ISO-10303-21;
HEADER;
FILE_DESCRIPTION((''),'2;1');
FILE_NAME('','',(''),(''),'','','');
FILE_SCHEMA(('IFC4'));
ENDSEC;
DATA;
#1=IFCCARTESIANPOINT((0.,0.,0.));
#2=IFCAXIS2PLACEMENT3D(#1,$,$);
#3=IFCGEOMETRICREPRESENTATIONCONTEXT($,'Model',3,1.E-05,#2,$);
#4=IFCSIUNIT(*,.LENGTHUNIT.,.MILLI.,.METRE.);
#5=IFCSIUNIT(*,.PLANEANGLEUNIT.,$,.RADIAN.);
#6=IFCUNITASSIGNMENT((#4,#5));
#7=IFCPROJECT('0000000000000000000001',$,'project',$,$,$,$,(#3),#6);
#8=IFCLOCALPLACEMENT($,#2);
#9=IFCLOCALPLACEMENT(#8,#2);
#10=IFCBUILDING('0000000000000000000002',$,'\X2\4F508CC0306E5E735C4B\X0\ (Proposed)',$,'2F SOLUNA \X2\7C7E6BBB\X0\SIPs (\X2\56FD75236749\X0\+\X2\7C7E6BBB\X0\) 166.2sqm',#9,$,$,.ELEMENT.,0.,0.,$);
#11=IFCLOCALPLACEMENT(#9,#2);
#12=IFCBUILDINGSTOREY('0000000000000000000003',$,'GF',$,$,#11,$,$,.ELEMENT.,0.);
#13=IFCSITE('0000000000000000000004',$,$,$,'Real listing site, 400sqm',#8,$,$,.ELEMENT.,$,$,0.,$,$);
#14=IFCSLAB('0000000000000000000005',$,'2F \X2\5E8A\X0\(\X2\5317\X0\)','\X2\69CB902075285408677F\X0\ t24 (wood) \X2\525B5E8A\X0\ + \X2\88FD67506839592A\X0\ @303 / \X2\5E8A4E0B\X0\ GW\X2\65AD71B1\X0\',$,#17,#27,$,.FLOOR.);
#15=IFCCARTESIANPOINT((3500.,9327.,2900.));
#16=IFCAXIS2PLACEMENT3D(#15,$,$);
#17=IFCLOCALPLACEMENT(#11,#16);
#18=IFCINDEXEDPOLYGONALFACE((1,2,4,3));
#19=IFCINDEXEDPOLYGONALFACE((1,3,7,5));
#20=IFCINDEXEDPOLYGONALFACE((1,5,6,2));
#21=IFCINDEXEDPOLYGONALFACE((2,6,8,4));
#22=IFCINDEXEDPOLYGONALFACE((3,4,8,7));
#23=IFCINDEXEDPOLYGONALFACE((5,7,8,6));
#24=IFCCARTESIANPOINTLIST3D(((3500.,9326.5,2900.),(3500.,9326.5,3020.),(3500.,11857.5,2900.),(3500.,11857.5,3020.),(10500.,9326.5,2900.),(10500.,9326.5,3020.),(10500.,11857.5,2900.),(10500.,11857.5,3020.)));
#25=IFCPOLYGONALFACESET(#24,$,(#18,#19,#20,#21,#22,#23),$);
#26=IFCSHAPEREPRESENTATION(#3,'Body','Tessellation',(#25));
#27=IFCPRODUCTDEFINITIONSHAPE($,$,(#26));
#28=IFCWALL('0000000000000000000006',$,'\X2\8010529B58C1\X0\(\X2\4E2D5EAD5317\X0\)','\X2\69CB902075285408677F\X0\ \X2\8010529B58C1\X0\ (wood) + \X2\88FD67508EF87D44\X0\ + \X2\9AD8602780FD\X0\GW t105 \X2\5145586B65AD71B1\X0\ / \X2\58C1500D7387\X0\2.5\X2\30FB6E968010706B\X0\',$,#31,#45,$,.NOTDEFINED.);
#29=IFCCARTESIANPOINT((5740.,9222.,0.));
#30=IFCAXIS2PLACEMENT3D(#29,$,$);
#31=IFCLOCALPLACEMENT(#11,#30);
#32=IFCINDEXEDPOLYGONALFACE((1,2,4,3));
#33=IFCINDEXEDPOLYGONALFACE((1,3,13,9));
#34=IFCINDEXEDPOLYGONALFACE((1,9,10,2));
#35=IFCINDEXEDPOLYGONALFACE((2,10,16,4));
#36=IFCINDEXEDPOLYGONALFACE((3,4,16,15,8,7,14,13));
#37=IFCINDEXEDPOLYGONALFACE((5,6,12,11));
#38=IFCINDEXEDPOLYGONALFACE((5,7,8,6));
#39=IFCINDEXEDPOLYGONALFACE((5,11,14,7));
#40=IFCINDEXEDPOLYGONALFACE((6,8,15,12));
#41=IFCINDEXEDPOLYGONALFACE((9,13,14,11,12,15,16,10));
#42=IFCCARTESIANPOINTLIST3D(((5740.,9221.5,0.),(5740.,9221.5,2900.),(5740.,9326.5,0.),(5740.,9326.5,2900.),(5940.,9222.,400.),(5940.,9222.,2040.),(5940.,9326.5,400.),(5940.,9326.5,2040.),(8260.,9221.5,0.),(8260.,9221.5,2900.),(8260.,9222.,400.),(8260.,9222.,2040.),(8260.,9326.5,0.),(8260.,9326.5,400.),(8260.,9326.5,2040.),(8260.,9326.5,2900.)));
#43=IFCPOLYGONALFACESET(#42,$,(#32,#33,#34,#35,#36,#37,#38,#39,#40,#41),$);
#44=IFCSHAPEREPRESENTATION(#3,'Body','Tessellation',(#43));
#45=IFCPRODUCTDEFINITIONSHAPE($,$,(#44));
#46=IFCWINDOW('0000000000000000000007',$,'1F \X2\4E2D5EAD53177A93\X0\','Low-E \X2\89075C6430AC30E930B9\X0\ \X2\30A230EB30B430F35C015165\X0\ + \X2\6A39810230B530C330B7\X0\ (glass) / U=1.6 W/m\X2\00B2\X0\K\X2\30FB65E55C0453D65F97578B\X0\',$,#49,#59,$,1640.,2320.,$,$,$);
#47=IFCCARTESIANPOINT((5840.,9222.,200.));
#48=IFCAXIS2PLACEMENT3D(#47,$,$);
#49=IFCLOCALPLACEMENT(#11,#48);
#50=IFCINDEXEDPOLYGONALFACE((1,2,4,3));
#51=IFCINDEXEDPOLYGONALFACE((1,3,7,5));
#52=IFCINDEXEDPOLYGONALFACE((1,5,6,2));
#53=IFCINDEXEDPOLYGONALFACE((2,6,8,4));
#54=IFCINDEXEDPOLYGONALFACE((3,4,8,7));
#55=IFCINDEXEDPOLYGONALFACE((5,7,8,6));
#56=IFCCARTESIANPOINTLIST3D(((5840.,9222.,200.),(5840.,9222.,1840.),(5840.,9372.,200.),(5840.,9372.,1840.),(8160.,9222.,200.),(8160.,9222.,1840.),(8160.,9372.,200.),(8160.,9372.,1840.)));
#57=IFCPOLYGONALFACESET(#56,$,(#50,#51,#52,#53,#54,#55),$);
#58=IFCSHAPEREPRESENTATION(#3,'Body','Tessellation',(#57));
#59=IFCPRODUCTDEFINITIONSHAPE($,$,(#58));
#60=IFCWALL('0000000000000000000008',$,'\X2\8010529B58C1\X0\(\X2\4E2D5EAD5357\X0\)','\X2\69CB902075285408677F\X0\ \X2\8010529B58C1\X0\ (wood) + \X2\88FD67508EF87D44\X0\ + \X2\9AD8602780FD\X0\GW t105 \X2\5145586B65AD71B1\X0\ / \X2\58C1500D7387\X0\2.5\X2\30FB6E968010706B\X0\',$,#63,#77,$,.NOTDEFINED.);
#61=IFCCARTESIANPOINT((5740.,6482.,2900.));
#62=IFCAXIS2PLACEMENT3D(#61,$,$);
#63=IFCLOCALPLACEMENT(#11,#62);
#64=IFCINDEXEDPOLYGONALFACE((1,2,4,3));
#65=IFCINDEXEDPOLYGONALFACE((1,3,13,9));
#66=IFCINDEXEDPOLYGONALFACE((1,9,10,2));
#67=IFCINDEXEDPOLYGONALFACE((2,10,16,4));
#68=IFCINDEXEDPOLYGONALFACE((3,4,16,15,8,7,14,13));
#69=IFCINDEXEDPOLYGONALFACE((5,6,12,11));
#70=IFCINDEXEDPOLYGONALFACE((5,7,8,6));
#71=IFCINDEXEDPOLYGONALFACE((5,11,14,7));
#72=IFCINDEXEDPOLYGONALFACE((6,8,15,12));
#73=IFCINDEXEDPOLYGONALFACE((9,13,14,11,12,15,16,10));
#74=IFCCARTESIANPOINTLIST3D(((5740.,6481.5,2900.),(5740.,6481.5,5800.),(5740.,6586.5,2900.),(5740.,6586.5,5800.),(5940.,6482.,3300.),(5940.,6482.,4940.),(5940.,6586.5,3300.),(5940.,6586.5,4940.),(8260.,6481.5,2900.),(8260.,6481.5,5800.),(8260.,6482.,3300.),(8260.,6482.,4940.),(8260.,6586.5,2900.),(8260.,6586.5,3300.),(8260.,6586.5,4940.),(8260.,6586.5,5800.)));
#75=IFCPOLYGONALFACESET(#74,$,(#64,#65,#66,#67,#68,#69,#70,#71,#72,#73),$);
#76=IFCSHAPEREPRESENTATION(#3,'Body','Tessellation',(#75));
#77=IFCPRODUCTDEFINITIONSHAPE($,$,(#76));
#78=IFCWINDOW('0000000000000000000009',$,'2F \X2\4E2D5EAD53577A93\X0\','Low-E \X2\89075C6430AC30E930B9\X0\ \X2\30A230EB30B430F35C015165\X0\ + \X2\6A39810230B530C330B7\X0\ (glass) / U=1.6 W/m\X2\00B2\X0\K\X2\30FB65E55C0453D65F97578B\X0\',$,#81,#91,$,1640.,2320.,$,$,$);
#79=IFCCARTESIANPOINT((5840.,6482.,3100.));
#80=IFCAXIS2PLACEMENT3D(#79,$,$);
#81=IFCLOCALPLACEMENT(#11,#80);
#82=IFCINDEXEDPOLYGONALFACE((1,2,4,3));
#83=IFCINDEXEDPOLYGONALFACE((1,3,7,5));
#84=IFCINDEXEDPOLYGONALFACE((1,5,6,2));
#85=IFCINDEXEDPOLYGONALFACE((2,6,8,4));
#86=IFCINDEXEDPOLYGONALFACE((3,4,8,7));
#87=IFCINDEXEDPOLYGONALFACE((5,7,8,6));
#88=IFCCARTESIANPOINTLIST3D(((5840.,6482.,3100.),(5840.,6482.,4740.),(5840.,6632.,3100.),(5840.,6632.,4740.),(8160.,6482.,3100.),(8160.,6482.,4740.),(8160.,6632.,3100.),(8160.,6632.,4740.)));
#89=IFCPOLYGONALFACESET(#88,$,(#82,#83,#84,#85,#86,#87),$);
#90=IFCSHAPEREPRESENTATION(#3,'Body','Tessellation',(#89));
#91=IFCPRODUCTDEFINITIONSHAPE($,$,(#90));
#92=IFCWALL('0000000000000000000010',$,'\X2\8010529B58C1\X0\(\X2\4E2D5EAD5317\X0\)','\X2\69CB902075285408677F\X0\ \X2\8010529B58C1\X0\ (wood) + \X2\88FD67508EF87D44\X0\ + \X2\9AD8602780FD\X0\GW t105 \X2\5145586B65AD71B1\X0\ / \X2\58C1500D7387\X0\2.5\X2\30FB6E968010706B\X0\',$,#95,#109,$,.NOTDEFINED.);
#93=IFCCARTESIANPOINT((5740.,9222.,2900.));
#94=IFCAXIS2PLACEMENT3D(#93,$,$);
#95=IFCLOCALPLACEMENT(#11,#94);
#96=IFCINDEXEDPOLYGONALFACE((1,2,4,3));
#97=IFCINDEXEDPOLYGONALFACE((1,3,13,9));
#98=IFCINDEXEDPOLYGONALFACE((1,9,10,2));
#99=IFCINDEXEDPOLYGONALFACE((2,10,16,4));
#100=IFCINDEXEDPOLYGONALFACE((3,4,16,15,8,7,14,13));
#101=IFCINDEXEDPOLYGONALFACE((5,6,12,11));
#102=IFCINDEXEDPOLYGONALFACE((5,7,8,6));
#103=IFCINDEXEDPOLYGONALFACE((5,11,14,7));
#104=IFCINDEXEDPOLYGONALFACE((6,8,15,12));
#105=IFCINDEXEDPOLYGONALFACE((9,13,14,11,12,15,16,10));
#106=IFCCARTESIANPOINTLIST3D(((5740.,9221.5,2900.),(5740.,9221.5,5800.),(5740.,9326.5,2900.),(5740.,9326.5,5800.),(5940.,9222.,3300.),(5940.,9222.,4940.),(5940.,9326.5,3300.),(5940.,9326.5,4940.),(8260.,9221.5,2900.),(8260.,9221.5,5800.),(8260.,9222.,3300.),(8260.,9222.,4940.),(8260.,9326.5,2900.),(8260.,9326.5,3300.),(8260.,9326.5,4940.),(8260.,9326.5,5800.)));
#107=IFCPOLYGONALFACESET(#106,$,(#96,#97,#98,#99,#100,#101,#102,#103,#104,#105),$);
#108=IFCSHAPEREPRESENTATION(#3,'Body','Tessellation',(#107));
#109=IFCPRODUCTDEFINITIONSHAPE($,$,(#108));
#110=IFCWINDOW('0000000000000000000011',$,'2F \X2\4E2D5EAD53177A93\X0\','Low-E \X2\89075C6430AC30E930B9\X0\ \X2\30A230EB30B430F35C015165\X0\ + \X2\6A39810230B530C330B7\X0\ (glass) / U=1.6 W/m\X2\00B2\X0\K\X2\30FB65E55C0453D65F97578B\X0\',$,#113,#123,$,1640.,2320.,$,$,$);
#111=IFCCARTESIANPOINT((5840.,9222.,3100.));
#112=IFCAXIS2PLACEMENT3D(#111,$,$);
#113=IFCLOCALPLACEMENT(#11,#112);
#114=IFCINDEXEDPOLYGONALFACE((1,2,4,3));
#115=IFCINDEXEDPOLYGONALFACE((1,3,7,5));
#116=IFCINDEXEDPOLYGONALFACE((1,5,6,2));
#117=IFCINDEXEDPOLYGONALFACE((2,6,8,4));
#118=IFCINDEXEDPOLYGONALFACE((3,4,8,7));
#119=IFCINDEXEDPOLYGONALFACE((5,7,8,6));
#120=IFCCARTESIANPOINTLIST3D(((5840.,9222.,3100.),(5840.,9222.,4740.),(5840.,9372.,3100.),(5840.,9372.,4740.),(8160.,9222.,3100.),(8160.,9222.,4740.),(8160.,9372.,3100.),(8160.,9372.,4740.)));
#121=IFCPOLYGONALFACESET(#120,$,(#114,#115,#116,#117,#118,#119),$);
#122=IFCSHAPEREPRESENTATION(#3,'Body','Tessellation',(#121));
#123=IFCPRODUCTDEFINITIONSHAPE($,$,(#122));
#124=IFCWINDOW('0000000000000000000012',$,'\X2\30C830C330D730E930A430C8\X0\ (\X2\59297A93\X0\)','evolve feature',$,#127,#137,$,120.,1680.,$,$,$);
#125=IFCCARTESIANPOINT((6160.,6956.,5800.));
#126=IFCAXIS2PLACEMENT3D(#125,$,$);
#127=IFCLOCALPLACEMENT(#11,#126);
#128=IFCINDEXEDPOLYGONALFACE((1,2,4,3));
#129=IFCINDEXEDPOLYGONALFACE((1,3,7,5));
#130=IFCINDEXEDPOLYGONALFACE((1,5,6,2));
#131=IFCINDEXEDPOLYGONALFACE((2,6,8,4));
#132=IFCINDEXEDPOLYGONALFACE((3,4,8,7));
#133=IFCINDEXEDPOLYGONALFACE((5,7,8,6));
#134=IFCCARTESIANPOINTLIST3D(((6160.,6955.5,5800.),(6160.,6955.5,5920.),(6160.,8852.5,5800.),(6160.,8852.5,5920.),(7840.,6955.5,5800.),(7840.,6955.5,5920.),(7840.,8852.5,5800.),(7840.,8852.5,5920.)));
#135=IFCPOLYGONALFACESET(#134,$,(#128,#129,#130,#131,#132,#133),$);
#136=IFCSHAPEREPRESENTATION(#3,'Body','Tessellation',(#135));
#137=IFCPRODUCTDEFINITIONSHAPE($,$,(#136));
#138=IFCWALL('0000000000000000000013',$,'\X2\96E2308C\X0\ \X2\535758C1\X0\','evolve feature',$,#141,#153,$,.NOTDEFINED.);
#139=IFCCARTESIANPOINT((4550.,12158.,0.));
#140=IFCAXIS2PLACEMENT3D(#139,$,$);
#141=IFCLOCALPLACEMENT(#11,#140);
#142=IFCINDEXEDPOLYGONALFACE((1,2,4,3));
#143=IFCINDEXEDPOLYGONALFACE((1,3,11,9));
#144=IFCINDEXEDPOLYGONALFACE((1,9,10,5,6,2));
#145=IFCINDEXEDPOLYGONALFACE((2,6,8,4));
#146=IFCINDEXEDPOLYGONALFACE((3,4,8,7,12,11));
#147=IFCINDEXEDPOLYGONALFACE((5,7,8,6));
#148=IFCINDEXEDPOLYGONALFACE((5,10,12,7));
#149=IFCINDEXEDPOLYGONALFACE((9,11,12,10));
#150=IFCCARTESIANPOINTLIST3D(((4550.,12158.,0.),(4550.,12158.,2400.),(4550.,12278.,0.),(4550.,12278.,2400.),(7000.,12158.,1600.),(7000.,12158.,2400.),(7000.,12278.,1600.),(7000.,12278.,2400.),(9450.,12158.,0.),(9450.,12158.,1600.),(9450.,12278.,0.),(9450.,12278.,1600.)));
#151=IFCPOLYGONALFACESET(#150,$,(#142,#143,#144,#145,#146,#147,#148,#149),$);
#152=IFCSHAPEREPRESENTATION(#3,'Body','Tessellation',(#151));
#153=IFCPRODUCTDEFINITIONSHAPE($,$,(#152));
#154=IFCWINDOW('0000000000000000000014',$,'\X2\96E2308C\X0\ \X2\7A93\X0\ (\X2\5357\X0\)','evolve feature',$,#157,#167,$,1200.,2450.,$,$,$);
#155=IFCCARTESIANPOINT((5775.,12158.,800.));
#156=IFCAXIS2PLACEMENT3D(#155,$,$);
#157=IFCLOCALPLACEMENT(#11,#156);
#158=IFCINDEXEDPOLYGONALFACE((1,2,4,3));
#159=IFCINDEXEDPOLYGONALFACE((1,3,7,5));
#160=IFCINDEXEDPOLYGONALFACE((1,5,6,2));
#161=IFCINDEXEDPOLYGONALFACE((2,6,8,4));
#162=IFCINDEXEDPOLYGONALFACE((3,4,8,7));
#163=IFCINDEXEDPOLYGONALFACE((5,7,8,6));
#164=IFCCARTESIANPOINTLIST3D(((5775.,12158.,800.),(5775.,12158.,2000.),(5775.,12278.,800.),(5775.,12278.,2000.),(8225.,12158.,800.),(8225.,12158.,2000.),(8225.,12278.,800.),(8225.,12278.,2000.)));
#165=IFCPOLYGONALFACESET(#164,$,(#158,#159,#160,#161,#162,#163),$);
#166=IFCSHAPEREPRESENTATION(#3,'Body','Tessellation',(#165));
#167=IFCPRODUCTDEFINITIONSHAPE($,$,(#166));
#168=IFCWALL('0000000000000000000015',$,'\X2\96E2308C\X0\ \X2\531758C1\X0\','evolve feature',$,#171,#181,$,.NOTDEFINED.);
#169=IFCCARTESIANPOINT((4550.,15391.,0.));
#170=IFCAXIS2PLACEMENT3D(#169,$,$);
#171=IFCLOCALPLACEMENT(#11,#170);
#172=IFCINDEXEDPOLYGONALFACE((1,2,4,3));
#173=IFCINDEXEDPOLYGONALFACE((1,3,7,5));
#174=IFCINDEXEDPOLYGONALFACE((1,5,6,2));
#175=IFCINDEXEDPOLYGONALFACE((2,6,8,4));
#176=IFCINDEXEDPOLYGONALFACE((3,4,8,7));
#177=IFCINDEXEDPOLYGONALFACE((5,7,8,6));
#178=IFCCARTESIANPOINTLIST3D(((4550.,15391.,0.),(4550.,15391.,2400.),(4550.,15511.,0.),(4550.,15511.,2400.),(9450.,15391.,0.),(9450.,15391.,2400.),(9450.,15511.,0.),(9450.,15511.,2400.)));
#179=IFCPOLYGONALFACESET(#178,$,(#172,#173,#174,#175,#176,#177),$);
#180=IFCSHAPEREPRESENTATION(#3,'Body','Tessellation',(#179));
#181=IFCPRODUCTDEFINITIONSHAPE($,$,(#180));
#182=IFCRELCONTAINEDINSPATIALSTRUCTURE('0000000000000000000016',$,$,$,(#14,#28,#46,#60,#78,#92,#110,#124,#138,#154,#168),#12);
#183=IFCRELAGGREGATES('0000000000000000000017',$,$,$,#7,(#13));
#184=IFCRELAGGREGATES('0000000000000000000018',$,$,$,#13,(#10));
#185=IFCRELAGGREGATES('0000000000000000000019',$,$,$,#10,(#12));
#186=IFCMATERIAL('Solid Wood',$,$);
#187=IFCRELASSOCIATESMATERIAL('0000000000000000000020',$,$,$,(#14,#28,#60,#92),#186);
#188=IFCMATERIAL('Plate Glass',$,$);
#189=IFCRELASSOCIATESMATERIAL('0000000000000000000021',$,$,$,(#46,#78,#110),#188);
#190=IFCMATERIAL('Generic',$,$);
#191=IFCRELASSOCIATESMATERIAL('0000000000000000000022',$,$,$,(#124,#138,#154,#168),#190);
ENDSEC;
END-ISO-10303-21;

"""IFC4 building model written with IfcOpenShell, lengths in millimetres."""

from ifc_helpers import new_model, si_unit, frame, frame_2d, origin, place, context, project, spatial, rectangle, extrude, material, element, fill, save


model = new_model("IFC4")

# Units and contexts
model_context = context("Model", 3, precision=1e-05, world=origin())
ifc_project = project(units=[si_unit("LENGTHUNIT", "METRE", prefix="MILLI"), si_unit("PLANEANGLEUNIT", "RADIAN")], contexts=[model_context])

# Site, building, storey
site_placement = place(None, origin())
site = spatial("IfcSite", under=ifc_project, at=site_placement, ObjectType="Real listing site, 400sqm", CompositionType="ELEMENT", RefElevation=0.0)
building_placement = place(site_placement, origin())
building = spatial("IfcBuilding", under=site, at=building_placement, Name="佐賀の平屋 (Proposed)", ObjectType="2F SOLUNA 籾殻SIPs (国産杉+籾殻) 166.2sqm", CompositionType="ELEMENT", ElevationOfRefHeight=0.0, ElevationOfTerrain=0.0)
storey_placement = place(building_placement, origin())
storey = spatial("IfcBuildingStorey", under=building, at=storey_placement, Name="GF", CompositionType="ELEMENT", Elevation=0.0)

# Slab
ifc_material_1 = material(Name="Solid Wood")
slab_1_placement = place(storey_placement, frame((3500.0, 9327.0, 2900.0)))
element("IfcSlab", 1, at=slab_1_placement, inside=storey, material=ifc_material_1, Name="2F 床(北)", Description="構造用合板 t24 (wood) 剛床 + 製材根太 @303 / 床下 GW断熱", PredefinedType="FLOOR", context=model_context, shape_type="SweptSolid", body=[
    extrude(rectangle(XDim=7000.0, YDim=2531.0, at=frame_2d((3500.0, 1265.0))), frame((3500.0, 9327.0, 2900.0)), (0.0, 0.0, 1.0), 120.0),
])
ifc_material_2 = material(Name="Generic")

# Wall, opening, window
wall_1_placement = place(storey_placement, frame((5740.0, 9222.0, 0.0)))
wall_1 = element("IfcWall", 2, at=wall_1_placement, inside=storey, material=ifc_material_1, Name="耐力壁(中庭北)", Description="構造用合板 耐力壁 (wood) + 製材軸組 + 高性能GW t105 充填断熱 / 壁倍率2.5・準耐火", PredefinedType="NOTDEFINED", context=model_context, shape_type="SweptSolid", body=[
    extrude(rectangle(XDim=2520.0, YDim=105.0, at=frame_2d((1260.0, 52.0))), frame((5740.0, 9222.0, 0.0)), (0.0, 0.0, 1.0), 2900.0),
])
opening_1_placement = place(storey_placement, frame((5840.0, 9222.0, 200.0)))
opening_1 = element("IfcOpeningElement", 3, at=opening_1_placement, cuts=wall_1, PredefinedType="NOTDEFINED", context=model_context, shape_type="SweptSolid", body=[
    extrude(rectangle(XDim=2320.0, YDim=150.0, at=frame_2d((1160.0, 75.0))), frame((5840.0, 9222.0, 200.0)), (0.0, 0.0, 1.0), 1640.0),
])
ifc_material_3 = material(Name="Plate Glass")
window_1_placement = place(storey_placement, frame((5840.0, 9222.0, 200.0)))
window_1 = element("IfcWindow", 4, at=window_1_placement, inside=storey, material=ifc_material_3, Name="1F 中庭北窓", Description="Low-E 複層ガラス アルゴン封入 + 樹脂サッシ (glass) / U=1.6 W/m²K・日射取得型", OverallHeight=1640.0, OverallWidth=2320.0, context=model_context, shape_type="SweptSolid", body=[
    extrude(rectangle(XDim=2320.0, YDim=150.0, at=frame_2d((1160.0, 75.0))), frame((5840.0, 9222.0, 200.0)), (0.0, 0.0, 1.0), 1640.0),
])
fill(opening_1, window_1)

# Walls, openings, windows
wall_2_placement = place(storey_placement, frame((5740.0, 6482.0, 2900.0)))
wall_2 = element("IfcWall", 5, at=wall_2_placement, inside=storey, material=ifc_material_1, Name="耐力壁(中庭南)", Description="構造用合板 耐力壁 (wood) + 製材軸組 + 高性能GW t105 充填断熱 / 壁倍率2.5・準耐火", PredefinedType="NOTDEFINED", context=model_context, shape_type="SweptSolid", body=[
    extrude(rectangle(XDim=2520.0, YDim=105.0, at=frame_2d((1260.0, 52.0))), frame((5740.0, 6482.0, 2900.0)), (0.0, 0.0, 1.0), 2900.0),
])
opening_2_placement = place(storey_placement, frame((5840.0, 6482.0, 3100.0)))
opening_2 = element("IfcOpeningElement", 6, at=opening_2_placement, cuts=wall_2, PredefinedType="NOTDEFINED", context=model_context, shape_type="SweptSolid", body=[
    extrude(rectangle(XDim=2320.0, YDim=150.0, at=frame_2d((1160.0, 75.0))), frame((5840.0, 6482.0, 3100.0)), (0.0, 0.0, 1.0), 1640.0),
])
window_2_placement = place(storey_placement, frame((5840.0, 6482.0, 3100.0)))
window_2 = element("IfcWindow", 7, at=window_2_placement, inside=storey, material=ifc_material_3, Name="2F 中庭南窓", Description="Low-E 複層ガラス アルゴン封入 + 樹脂サッシ (glass) / U=1.6 W/m²K・日射取得型", OverallHeight=1640.0, OverallWidth=2320.0, context=model_context, shape_type="SweptSolid", body=[
    extrude(rectangle(XDim=2320.0, YDim=150.0, at=frame_2d((1160.0, 75.0))), frame((5840.0, 6482.0, 3100.0)), (0.0, 0.0, 1.0), 1640.0),
])
fill(opening_2, window_2)
wall_3_placement = place(storey_placement, frame((5740.0, 9222.0, 2900.0)))
wall_3 = element("IfcWall", 8, at=wall_3_placement, inside=storey, material=ifc_material_1, Name="耐力壁(中庭北)", Description="構造用合板 耐力壁 (wood) + 製材軸組 + 高性能GW t105 充填断熱 / 壁倍率2.5・準耐火", PredefinedType="NOTDEFINED", context=model_context, shape_type="SweptSolid", body=[
    extrude(rectangle(XDim=2520.0, YDim=105.0, at=frame_2d((1260.0, 52.0))), frame((5740.0, 9222.0, 2900.0)), (0.0, 0.0, 1.0), 2900.0),
])
opening_3_placement = place(storey_placement, frame((5840.0, 9222.0, 3100.0)))
opening_3 = element("IfcOpeningElement", 9, at=opening_3_placement, cuts=wall_3, PredefinedType="NOTDEFINED", context=model_context, shape_type="SweptSolid", body=[
    extrude(rectangle(XDim=2320.0, YDim=150.0, at=frame_2d((1160.0, 75.0))), frame((5840.0, 9222.0, 3100.0)), (0.0, 0.0, 1.0), 1640.0),
])
window_3_placement = place(storey_placement, frame((5840.0, 9222.0, 3100.0)))
window_3 = element("IfcWindow", 10, at=window_3_placement, inside=storey, material=ifc_material_3, Name="2F 中庭北窓", Description="Low-E 複層ガラス アルゴン封入 + 樹脂サッシ (glass) / U=1.6 W/m²K・日射取得型", OverallHeight=1640.0, OverallWidth=2320.0, context=model_context, shape_type="SweptSolid", body=[
    extrude(rectangle(XDim=2320.0, YDim=150.0, at=frame_2d((1160.0, 75.0))), frame((5840.0, 9222.0, 3100.0)), (0.0, 0.0, 1.0), 1640.0),
])
fill(opening_3, window_3)

# Window
window_4_placement = place(storey_placement, frame((6160.0, 6956.0, 5800.0)))
element("IfcWindow", 11, at=window_4_placement, inside=storey, material=ifc_material_2, Name="トップライト (天窓)", Description="evolve feature", OverallHeight=120.0, OverallWidth=1680.0, context=model_context, shape_type="SweptSolid", body=[
    extrude(rectangle(XDim=1680.0, YDim=1897.0, at=frame_2d((840.0, 948.0))), frame((6160.0, 6956.0, 5800.0)), (0.0, 0.0, 1.0), 120.0),
])

# Wall, opening, window
wall_4_placement = place(storey_placement, frame((4550.0, 12158.0, 0.0)))
wall_4 = element("IfcWall", 12, at=wall_4_placement, inside=storey, material=ifc_material_2, Name="離れ 南壁", Description="evolve feature", PredefinedType="NOTDEFINED", context=model_context, shape_type="SweptSolid", body=[
    extrude(rectangle(XDim=4900.0, YDim=120.0, at=frame_2d((2450.0, 60.0))), frame((4550.0, 12158.0, 0.0)), (0.0, 0.0, 1.0), 2400.0),
])
opening_4_placement = place(storey_placement, frame((5775.0, 12158.0, 800.0)))
opening_4 = element("IfcOpeningElement", 13, at=opening_4_placement, cuts=wall_4, PredefinedType="NOTDEFINED", context=model_context, shape_type="SweptSolid", body=[
    extrude(rectangle(XDim=2450.0, YDim=120.0, at=frame_2d((1225.0, 60.0))), frame((5775.0, 12158.0, 800.0)), (0.0, 0.0, 1.0), 1200.0),
])
window_5_placement = place(storey_placement, frame((5775.0, 12158.0, 800.0)))
window_5 = element("IfcWindow", 14, at=window_5_placement, inside=storey, material=ifc_material_2, Name="離れ 窓 (南)", Description="evolve feature", OverallHeight=1200.0, OverallWidth=2450.0, context=model_context, shape_type="SweptSolid", body=[
    extrude(rectangle(XDim=2450.0, YDim=120.0, at=frame_2d((1225.0, 60.0))), frame((5775.0, 12158.0, 800.0)), (0.0, 0.0, 1.0), 1200.0),
])
fill(opening_4, window_5)

# Wall
wall_5_placement = place(storey_placement, frame((4550.0, 15391.0, 0.0)))
element("IfcWall", 15, at=wall_5_placement, inside=storey, material=ifc_material_2, Name="離れ 北壁", Description="evolve feature", PredefinedType="NOTDEFINED", context=model_context, shape_type="SweptSolid", body=[
    extrude(rectangle(XDim=4900.0, YDim=120.0, at=frame_2d((2450.0, 60.0))), frame((4550.0, 15391.0, 0.0)), (0.0, 0.0, 1.0), 2400.0),
])

save(model, "model.ifc")
